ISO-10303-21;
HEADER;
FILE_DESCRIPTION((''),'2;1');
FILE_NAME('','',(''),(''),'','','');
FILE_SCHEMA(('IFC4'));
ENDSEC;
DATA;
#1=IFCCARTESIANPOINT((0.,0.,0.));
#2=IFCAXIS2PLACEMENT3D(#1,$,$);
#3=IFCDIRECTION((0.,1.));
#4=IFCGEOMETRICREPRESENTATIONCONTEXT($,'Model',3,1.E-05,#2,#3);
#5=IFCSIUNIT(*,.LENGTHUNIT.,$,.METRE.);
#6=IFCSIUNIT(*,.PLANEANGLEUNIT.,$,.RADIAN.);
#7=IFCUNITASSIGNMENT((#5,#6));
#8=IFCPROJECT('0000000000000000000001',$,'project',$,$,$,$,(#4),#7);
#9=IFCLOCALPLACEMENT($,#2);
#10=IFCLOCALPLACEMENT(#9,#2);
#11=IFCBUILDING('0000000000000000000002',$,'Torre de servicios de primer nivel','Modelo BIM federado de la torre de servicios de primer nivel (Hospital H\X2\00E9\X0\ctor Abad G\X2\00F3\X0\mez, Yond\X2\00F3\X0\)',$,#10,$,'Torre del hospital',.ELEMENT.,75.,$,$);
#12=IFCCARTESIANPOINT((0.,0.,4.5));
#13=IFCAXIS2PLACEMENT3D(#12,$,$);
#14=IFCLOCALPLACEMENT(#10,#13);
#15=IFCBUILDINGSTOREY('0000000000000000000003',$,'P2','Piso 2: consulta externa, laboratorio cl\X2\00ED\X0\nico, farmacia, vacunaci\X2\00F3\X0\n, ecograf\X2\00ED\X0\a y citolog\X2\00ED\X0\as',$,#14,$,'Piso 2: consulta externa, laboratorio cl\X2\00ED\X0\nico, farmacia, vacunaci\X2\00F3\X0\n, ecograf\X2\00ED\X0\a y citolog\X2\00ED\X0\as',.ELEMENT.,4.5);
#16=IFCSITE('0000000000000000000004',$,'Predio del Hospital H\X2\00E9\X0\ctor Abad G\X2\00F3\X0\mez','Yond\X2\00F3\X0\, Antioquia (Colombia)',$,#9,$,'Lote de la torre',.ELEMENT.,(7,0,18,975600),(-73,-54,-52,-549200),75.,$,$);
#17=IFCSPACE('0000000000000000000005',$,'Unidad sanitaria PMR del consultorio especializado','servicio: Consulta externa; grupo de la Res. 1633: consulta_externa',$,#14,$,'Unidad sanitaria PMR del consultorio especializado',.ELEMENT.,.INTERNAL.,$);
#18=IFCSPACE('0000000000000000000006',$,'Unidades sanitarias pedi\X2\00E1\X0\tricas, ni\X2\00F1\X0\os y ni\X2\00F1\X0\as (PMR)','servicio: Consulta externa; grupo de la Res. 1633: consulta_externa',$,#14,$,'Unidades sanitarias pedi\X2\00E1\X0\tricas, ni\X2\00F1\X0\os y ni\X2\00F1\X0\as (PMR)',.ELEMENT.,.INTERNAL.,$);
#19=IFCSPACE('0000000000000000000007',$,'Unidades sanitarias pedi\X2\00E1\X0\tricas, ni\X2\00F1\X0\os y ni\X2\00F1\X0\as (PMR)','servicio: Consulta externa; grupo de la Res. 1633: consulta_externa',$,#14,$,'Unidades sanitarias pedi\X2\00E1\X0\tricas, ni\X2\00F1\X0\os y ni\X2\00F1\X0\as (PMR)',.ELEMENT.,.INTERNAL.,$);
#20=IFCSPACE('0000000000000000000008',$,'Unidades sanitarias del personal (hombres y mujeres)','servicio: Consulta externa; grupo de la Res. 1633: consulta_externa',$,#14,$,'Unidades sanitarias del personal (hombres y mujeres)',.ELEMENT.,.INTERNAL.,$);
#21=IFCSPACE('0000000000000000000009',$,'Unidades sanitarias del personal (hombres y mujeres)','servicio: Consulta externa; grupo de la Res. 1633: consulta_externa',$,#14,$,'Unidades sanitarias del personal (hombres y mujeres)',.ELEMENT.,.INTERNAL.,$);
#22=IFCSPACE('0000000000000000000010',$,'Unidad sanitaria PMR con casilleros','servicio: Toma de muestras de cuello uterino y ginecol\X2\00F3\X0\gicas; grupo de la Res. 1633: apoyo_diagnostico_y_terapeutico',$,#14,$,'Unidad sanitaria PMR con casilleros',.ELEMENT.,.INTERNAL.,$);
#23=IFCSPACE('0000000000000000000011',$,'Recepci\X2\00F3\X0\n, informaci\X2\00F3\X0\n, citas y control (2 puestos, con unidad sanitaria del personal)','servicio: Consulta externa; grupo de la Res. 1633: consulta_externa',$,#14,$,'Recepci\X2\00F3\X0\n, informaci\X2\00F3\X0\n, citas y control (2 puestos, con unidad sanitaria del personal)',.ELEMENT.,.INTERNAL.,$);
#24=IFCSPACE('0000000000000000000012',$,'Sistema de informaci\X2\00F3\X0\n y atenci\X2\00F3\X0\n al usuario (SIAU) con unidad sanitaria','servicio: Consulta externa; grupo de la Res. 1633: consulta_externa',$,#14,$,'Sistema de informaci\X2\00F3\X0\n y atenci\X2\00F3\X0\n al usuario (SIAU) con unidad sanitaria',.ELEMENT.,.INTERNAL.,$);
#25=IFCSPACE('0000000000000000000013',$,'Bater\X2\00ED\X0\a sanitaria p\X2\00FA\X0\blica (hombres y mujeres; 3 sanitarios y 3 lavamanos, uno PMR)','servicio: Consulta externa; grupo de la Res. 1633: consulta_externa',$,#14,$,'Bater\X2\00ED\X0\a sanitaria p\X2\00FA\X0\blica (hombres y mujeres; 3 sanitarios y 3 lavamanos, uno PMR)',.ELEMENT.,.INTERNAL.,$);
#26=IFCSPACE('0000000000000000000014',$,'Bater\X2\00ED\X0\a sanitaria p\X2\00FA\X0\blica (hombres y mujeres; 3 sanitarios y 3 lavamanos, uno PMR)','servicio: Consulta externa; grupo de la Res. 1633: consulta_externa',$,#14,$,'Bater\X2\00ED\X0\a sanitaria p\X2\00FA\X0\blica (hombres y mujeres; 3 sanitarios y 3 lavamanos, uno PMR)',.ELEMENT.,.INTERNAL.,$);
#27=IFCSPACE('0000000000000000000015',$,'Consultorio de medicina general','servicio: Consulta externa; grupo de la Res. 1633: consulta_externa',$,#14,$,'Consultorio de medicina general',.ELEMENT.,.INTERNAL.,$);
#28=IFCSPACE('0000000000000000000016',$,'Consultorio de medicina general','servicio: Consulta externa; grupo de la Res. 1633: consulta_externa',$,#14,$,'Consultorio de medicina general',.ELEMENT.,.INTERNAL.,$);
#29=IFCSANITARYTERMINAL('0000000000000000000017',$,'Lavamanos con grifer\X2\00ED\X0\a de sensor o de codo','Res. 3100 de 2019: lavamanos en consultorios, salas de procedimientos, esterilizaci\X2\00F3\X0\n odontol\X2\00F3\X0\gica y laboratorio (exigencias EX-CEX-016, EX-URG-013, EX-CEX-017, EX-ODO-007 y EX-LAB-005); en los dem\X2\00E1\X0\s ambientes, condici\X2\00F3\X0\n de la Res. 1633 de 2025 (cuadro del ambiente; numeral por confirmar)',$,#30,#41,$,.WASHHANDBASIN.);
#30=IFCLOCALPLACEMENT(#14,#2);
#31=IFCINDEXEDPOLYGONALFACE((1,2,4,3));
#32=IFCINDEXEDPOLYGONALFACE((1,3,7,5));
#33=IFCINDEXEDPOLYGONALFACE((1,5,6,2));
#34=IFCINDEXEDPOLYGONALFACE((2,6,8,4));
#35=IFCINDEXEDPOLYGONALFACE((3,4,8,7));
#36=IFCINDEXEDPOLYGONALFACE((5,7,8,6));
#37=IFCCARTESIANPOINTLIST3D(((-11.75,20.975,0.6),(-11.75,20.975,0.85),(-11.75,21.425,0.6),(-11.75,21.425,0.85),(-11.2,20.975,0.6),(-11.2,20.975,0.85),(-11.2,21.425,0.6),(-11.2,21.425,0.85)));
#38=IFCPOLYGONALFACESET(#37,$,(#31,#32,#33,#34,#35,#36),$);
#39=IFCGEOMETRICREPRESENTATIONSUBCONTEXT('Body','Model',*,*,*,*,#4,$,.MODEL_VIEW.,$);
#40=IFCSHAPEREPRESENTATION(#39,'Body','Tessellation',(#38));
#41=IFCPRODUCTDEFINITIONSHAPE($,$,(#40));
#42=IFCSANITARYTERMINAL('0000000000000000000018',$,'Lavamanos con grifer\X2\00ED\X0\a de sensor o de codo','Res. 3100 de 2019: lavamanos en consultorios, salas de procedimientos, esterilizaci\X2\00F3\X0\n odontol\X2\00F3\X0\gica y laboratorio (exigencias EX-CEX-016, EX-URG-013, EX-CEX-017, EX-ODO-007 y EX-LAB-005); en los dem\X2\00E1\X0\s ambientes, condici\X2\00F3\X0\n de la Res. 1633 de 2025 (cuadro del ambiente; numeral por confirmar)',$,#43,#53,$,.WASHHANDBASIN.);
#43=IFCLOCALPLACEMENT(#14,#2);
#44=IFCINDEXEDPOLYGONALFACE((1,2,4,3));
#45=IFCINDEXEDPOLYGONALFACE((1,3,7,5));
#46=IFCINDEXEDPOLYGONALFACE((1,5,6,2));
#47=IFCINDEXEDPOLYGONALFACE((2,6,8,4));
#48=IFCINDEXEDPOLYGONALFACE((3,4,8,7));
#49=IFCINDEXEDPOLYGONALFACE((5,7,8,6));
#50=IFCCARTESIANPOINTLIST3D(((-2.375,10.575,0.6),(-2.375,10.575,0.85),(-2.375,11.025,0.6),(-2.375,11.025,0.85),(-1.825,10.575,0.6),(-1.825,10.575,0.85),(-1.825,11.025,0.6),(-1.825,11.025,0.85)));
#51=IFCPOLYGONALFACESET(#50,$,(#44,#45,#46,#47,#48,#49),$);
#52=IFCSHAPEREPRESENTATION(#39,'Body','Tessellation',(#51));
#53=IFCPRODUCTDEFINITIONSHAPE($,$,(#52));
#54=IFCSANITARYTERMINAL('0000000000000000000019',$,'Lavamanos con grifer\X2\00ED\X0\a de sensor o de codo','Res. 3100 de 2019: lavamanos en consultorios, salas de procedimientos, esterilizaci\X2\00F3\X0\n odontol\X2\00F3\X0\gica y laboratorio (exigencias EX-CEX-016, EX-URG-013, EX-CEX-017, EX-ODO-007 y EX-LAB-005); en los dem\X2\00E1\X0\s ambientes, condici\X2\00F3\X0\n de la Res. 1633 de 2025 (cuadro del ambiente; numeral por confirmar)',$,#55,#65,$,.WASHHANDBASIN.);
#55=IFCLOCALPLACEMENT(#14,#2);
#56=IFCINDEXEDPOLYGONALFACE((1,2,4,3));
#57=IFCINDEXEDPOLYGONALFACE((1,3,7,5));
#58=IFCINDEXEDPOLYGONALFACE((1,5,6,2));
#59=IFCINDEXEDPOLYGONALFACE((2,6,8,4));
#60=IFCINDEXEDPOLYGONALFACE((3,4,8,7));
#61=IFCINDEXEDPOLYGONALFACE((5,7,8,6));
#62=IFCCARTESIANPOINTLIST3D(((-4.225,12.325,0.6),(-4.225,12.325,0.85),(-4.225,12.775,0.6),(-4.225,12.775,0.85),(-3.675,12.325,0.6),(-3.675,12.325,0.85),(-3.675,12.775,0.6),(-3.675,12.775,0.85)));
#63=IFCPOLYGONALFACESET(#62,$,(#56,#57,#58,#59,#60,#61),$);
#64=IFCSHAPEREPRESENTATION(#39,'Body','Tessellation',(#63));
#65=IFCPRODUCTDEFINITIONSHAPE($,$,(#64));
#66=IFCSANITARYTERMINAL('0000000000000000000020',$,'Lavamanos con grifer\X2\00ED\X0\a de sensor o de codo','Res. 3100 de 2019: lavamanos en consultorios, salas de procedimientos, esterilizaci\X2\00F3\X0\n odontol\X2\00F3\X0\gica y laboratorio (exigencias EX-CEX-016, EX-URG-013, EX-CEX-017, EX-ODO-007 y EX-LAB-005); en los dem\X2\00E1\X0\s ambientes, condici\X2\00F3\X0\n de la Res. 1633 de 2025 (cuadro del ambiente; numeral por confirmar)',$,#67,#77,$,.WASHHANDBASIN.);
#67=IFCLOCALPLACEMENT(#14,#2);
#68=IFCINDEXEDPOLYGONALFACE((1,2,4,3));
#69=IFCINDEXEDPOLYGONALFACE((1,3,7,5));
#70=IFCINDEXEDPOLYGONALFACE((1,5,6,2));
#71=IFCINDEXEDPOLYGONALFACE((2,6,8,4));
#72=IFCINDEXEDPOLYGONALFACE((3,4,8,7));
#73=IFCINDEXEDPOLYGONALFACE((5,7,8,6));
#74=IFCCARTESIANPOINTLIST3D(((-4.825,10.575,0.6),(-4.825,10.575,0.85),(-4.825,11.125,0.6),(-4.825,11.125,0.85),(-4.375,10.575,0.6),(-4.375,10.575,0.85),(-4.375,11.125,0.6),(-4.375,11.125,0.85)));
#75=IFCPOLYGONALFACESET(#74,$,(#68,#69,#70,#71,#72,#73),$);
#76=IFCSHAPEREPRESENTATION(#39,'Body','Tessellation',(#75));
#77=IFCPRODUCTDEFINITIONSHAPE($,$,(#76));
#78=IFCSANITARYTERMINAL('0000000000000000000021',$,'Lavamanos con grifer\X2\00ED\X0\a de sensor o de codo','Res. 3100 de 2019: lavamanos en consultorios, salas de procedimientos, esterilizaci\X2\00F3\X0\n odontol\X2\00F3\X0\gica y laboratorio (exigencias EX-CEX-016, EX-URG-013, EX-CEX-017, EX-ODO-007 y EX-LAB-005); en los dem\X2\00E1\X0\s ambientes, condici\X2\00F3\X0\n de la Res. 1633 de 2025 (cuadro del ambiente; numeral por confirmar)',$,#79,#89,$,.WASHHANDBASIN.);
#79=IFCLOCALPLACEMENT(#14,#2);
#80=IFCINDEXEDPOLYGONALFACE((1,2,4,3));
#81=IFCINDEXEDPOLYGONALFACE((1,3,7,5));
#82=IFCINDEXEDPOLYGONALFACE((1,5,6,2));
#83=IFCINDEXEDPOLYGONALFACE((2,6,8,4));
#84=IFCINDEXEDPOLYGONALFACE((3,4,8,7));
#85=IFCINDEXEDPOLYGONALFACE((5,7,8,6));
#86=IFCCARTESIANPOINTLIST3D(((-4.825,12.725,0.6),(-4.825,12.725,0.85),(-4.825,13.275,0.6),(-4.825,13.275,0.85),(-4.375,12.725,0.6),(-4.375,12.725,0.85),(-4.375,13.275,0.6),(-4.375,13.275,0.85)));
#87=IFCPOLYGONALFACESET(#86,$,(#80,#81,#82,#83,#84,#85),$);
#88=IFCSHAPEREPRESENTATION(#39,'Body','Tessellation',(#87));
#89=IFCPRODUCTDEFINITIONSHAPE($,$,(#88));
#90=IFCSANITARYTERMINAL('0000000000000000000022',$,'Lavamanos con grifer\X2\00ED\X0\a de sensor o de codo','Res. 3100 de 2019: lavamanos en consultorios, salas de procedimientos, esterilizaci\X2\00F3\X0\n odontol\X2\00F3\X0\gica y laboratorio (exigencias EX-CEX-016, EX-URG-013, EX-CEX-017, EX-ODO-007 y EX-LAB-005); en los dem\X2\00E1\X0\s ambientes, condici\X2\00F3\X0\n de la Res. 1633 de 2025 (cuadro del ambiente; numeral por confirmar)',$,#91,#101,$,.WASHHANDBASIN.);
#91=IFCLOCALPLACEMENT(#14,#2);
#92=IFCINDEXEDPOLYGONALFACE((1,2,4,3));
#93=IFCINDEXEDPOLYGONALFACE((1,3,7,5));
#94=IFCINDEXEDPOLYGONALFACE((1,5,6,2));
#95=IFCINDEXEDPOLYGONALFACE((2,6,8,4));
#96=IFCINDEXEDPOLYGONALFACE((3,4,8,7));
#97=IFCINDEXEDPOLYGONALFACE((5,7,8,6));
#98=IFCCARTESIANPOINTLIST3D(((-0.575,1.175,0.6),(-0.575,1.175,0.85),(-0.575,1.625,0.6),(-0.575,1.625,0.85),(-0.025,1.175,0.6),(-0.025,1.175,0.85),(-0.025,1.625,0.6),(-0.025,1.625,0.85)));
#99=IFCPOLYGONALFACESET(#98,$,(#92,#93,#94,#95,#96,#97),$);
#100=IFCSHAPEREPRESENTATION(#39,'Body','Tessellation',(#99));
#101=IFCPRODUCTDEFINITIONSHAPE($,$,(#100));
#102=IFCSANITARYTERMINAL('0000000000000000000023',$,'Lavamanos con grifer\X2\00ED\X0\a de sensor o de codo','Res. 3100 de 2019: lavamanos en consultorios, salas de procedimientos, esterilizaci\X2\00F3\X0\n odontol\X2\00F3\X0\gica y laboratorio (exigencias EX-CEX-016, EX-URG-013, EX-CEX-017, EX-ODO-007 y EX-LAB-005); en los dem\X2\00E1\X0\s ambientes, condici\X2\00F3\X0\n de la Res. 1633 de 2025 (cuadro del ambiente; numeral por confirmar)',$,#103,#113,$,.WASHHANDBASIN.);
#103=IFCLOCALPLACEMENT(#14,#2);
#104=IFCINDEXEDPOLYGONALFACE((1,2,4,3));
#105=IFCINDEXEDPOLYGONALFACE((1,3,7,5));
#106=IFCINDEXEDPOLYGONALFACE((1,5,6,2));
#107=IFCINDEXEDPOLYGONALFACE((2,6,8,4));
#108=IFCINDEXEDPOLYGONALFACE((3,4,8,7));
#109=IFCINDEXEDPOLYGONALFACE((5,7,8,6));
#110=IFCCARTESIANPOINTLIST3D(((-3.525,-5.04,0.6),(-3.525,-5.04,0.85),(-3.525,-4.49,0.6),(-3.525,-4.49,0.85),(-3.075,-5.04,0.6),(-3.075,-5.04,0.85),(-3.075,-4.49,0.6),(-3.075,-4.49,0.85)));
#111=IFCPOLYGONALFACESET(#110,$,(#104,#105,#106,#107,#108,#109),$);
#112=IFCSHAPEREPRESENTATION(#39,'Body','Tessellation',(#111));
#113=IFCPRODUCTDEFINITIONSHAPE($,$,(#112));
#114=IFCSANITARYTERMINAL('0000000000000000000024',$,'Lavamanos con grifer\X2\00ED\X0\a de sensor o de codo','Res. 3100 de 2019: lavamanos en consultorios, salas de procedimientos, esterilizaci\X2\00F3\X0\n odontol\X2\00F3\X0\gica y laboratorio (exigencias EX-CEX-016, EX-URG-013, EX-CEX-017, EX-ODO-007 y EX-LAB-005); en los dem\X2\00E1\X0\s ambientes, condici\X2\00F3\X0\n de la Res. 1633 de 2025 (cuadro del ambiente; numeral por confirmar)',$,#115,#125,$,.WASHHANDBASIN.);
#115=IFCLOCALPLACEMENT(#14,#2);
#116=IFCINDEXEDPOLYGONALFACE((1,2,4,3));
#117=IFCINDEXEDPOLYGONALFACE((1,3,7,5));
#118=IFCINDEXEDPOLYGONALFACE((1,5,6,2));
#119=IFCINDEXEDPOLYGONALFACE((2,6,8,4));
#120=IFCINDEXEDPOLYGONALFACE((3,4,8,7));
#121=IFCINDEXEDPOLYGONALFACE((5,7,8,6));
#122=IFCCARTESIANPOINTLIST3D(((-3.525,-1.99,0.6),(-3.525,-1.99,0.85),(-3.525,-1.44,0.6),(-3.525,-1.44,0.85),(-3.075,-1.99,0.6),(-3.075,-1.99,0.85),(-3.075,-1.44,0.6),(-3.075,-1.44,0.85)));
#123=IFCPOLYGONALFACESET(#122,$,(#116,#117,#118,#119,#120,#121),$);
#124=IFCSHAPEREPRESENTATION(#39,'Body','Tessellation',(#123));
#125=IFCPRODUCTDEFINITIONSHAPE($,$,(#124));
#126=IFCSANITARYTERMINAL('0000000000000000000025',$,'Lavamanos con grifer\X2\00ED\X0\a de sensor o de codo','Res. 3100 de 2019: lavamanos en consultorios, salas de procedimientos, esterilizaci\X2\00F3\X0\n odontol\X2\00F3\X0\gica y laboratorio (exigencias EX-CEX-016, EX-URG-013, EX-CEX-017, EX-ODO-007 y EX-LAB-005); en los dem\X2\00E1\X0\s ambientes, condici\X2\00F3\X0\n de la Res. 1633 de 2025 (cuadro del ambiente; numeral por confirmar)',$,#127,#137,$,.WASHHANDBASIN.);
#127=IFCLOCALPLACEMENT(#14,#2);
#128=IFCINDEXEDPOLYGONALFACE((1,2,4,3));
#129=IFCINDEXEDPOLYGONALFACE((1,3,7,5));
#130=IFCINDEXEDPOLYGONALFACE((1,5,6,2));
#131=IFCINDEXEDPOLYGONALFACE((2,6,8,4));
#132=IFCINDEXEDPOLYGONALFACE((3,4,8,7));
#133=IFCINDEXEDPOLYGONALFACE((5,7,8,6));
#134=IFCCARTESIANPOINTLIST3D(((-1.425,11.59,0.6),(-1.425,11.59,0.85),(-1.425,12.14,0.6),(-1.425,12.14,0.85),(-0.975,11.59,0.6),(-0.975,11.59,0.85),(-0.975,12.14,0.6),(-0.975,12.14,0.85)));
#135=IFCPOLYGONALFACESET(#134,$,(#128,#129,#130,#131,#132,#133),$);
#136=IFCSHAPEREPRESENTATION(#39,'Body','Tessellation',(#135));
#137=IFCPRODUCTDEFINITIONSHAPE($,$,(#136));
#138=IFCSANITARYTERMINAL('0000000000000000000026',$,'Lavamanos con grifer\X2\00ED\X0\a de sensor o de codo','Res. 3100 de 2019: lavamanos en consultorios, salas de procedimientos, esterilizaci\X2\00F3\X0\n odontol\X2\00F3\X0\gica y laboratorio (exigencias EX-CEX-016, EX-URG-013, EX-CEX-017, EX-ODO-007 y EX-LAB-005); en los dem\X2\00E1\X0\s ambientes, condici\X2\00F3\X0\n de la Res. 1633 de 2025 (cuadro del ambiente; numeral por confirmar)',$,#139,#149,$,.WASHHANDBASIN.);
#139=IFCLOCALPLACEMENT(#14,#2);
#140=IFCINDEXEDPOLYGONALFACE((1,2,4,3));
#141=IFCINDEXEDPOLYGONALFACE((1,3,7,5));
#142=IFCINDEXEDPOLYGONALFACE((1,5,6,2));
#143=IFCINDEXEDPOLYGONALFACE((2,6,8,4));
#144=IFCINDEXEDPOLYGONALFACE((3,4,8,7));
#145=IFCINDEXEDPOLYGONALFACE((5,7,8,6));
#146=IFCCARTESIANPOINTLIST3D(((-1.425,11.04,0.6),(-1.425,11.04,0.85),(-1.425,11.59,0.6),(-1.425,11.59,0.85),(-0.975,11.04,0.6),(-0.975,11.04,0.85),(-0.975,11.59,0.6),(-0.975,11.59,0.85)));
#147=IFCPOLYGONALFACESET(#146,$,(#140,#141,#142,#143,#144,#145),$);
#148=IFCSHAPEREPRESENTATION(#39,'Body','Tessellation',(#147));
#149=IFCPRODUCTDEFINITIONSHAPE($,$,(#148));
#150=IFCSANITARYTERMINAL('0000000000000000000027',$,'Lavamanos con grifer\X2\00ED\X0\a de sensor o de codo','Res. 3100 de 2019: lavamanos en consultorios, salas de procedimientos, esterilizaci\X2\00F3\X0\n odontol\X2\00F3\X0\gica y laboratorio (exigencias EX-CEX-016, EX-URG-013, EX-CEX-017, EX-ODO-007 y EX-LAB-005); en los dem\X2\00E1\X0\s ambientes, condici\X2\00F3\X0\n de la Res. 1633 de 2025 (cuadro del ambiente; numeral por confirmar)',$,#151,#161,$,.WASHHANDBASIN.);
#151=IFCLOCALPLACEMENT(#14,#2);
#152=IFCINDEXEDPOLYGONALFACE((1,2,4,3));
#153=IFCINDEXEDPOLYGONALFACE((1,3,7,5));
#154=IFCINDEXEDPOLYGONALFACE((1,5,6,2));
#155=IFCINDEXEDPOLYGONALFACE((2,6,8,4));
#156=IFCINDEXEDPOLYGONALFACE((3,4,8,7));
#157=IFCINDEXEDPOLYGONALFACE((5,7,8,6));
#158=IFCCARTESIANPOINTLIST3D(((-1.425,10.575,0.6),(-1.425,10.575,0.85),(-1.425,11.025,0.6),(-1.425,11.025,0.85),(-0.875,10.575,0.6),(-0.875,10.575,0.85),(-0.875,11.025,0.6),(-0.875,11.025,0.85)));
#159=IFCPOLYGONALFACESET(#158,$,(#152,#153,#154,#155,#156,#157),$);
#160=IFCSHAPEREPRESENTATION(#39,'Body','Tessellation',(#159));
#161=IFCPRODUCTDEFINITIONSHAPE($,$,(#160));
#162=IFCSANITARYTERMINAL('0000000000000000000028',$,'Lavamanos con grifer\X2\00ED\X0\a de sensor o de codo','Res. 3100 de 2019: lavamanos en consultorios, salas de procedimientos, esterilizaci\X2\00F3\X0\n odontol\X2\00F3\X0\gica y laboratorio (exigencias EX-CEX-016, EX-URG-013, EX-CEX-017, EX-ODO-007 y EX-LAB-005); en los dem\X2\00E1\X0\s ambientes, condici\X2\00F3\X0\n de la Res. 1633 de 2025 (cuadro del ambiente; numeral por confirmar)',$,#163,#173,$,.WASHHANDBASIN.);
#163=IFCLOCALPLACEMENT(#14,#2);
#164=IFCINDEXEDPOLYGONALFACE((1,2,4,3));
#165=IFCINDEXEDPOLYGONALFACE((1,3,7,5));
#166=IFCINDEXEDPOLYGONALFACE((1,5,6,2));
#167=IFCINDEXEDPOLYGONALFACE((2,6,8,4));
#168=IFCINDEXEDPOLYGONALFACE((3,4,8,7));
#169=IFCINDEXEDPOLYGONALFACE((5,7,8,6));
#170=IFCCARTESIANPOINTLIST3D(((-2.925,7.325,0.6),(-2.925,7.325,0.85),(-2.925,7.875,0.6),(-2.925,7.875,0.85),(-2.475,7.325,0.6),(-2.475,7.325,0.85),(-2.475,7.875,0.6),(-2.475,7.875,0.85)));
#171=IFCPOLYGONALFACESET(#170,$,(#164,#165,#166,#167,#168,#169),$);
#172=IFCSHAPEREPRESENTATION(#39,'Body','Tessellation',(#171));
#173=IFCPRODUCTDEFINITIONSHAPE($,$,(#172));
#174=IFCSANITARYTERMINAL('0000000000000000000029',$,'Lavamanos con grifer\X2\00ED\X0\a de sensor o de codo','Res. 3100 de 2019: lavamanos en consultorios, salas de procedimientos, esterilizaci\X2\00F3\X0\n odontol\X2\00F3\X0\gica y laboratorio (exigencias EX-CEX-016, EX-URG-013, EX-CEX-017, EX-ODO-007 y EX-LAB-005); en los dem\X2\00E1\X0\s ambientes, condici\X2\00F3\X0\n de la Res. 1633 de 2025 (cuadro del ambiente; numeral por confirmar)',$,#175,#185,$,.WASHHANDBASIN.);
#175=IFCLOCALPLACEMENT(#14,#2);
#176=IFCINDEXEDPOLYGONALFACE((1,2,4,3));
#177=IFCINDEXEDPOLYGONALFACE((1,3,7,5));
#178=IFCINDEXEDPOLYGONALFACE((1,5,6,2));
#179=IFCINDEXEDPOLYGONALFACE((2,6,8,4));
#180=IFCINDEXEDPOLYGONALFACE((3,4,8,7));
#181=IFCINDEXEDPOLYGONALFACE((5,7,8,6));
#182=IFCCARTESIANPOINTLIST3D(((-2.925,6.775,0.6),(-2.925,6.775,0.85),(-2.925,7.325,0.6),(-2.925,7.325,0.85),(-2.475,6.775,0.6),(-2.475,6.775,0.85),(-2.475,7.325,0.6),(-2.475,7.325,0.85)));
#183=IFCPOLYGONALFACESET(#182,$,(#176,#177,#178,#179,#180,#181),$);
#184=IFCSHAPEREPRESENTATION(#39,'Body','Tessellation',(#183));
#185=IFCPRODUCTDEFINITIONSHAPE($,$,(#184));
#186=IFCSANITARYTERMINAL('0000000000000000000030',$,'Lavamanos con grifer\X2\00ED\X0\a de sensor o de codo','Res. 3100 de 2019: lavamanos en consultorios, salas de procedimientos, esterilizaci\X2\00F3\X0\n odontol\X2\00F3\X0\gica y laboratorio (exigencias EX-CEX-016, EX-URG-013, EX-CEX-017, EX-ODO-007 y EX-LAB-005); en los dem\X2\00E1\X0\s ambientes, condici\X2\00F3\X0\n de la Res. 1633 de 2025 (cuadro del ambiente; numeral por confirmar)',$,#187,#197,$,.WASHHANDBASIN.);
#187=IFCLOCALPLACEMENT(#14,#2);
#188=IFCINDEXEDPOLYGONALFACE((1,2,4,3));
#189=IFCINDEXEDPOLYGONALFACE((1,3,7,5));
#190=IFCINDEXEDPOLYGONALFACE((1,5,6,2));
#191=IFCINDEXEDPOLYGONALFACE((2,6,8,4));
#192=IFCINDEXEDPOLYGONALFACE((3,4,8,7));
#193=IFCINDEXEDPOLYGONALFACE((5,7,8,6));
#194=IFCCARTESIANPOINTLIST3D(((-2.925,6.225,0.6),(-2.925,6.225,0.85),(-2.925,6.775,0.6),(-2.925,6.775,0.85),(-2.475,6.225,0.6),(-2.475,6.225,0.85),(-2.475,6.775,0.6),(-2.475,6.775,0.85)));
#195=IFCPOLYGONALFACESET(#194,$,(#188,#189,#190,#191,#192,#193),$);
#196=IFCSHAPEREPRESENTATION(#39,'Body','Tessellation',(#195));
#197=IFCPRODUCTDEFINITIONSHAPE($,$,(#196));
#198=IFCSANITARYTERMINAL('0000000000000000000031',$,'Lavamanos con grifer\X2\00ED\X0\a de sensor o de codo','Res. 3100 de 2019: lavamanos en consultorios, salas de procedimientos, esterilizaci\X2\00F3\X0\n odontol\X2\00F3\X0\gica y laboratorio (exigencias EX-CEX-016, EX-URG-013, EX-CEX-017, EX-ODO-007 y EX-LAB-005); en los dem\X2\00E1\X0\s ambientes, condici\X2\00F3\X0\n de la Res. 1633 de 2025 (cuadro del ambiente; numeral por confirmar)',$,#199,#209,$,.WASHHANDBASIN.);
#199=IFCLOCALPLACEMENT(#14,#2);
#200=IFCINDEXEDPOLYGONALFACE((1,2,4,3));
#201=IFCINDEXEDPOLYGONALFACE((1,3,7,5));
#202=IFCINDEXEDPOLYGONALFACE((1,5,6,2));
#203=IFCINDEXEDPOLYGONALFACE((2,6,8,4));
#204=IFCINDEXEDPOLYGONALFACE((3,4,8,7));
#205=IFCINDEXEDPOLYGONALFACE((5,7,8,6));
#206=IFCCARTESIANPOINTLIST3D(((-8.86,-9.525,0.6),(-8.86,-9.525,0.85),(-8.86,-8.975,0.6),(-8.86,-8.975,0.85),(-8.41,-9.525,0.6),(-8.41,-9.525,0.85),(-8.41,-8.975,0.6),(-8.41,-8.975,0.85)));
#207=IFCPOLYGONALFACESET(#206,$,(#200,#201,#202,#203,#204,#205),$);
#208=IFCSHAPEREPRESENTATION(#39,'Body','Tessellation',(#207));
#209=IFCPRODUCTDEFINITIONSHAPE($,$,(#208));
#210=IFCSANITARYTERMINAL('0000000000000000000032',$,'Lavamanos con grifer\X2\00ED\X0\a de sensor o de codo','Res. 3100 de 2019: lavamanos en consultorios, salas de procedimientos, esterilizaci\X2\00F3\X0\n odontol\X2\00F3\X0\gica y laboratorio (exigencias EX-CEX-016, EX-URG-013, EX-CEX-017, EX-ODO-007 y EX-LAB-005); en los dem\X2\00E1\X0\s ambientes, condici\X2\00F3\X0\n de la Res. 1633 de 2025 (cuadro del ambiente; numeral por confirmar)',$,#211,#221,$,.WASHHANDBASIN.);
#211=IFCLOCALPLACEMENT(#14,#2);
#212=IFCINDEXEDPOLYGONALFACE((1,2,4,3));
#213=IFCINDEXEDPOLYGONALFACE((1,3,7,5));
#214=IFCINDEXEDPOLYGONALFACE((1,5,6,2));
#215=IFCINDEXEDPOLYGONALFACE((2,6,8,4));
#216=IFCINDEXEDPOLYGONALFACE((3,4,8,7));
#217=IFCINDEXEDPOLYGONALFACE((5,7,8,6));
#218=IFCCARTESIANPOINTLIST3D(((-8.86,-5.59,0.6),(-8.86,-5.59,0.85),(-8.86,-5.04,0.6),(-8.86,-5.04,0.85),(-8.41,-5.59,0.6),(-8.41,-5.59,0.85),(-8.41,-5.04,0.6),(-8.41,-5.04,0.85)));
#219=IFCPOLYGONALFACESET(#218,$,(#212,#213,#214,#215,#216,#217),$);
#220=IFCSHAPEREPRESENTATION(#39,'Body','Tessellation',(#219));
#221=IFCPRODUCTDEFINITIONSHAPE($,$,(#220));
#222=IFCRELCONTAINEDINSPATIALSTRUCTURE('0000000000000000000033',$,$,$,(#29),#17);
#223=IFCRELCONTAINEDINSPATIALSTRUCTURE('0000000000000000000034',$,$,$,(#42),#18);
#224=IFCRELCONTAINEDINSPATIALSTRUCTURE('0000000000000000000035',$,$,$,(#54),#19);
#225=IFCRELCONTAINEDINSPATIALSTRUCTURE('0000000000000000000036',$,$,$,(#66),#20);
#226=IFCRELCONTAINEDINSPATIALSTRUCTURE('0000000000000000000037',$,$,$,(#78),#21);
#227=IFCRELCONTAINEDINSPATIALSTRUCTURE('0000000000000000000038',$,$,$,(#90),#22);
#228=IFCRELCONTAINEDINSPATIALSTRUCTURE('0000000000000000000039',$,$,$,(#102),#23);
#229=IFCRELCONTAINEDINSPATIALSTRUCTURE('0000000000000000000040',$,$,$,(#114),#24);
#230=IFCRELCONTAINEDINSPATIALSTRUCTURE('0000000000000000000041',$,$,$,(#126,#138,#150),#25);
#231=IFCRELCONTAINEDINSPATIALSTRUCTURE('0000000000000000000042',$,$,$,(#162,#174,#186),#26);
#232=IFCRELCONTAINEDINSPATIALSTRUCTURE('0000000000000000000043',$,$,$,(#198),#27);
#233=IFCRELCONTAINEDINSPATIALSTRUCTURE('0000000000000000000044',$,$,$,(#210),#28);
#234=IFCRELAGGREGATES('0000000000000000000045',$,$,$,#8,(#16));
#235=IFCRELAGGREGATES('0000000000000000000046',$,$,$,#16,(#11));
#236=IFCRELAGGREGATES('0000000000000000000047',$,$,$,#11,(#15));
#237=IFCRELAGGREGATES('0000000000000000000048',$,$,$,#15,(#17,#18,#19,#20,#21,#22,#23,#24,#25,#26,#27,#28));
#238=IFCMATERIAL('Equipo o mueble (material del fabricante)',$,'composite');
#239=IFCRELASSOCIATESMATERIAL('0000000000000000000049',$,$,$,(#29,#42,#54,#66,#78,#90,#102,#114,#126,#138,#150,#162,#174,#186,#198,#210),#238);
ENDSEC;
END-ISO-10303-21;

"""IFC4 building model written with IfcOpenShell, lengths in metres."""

from ifc_helpers import new_model, si_unit, direction, frame, origin, place, context, subcontext, project, spatial, rectangle, extrude, material, element, save


model = new_model("IFC4")

# Units and contexts
model_context = context("Model", 3, precision=1e-05, world=origin(), true_north=direction((0.0, 1.0)))
body_context = subcontext(model_context, "Body", "Model", "MODEL_VIEW")
ifc_project = project(units=[si_unit("LENGTHUNIT", "METRE"), si_unit("PLANEANGLEUNIT", "RADIAN")], contexts=[model_context])

# Site, building, storey, space
site_placement = place(None, origin())
site = spatial("IfcSite", under=ifc_project, at=site_placement, Name="Predio del Hospital Héctor Abad Gómez", Description="Yondó, Antioquia (Colombia)", LongName="Lote de la torre", CompositionType="ELEMENT", RefLatitude=(7, 0, 18, 975600), RefLongitude=(-73, -54, -52, -549200), RefElevation=75.0)
building_placement = place(site_placement, origin())
building = spatial("IfcBuilding", under=site, at=building_placement, Name="Torre de servicios de primer nivel", Description="Modelo BIM federado de la torre de servicios de primer nivel (Hospital Héctor Abad Gómez, Yondó)", LongName="Torre del hospital", CompositionType="ELEMENT", ElevationOfRefHeight=75.0)
placement = place(building_placement, frame((0.0, 0.0, 4.5)))
storey = spatial("IfcBuildingStorey", under=building, at=placement, Name="P2", Description="Piso 2: consulta externa, laboratorio clínico, farmacia, vacunación, ecografía y citologías", LongName="Piso 2: consulta externa, laboratorio clínico, farmacia, vacunación, ecografía y citologías", CompositionType="ELEMENT", Elevation=4.5)
space_1 = spatial("IfcSpace", under=storey, at=placement, Name="Unidad sanitaria PMR del consultorio especializado", Description="servicio: Consulta externa; grupo de la Res. 1633: consulta_externa", LongName="Unidad sanitaria PMR del consultorio especializado", CompositionType="ELEMENT", PredefinedType="INTERNAL")

# Sanitary terminal
ifc_material = material(Name="Equipo o mueble (material del fabricante)", Category="composite")
element("IfcSanitaryTerminal", 1, at=placement, inside=space_1, material=ifc_material, Name="Lavamanos con grifería de sensor o de codo", Description="Res. 3100 de 2019: lavamanos en consultorios, salas de procedimientos, esterilización odontológica y laboratorio (exigencias EX-CEX-016, EX-URG-013, EX-CEX-017, EX-ODO-007 y EX-LAB-005); en los demás ambientes, condición de la Res. 1633 de 2025 (cuadro del ambiente; numeral por confirmar)", PredefinedType="WASHHANDBASIN", context=body_context, shape_type="SweptSolid", body=[
    extrude(rectangle(XDim=0.55, YDim=0.45), frame((-11.475, 21.2, 0.6)), (0.0, 0.0, 1.0), 0.25),
])

# Shared definitions
space_2 = spatial("IfcSpace", under=storey, at=placement, Name="Unidades sanitarias pediátricas, niños y niñas (PMR)", Description="servicio: Consulta externa; grupo de la Res. 1633: consulta_externa", LongName="Unidades sanitarias pediátricas, niños y niñas (PMR)", CompositionType="ELEMENT", PredefinedType="INTERNAL")

# Sanitary terminal
element("IfcSanitaryTerminal", 2, at=placement, inside=space_2, material=ifc_material, Name="Lavamanos con grifería de sensor o de codo", Description="Res. 3100 de 2019: lavamanos en consultorios, salas de procedimientos, esterilización odontológica y laboratorio (exigencias EX-CEX-016, EX-URG-013, EX-CEX-017, EX-ODO-007 y EX-LAB-005); en los demás ambientes, condición de la Res. 1633 de 2025 (cuadro del ambiente; numeral por confirmar)", PredefinedType="WASHHANDBASIN", context=body_context, shape_type="SweptSolid", body=[
    extrude(rectangle(XDim=0.55, YDim=0.45), frame((-2.1, 10.8, 0.6)), (0.0, 0.0, 1.0), 0.25),
])

# Shared definitions
space_3 = spatial("IfcSpace", under=storey, at=placement, Name="Unidades sanitarias pediátricas, niños y niñas (PMR)", Description="servicio: Consulta externa; grupo de la Res. 1633: consulta_externa", LongName="Unidades sanitarias pediátricas, niños y niñas (PMR)", CompositionType="ELEMENT", PredefinedType="INTERNAL")

# Sanitary terminal
element("IfcSanitaryTerminal", 3, at=placement, inside=space_3, material=ifc_material, Name="Lavamanos con grifería de sensor o de codo", Description="Res. 3100 de 2019: lavamanos en consultorios, salas de procedimientos, esterilización odontológica y laboratorio (exigencias EX-CEX-016, EX-URG-013, EX-CEX-017, EX-ODO-007 y EX-LAB-005); en los demás ambientes, condición de la Res. 1633 de 2025 (cuadro del ambiente; numeral por confirmar)", PredefinedType="WASHHANDBASIN", context=body_context, shape_type="SweptSolid", body=[
    extrude(rectangle(XDim=0.55, YDim=0.45), frame((-3.95, 12.55, 0.6)), (0.0, 0.0, 1.0), 0.25),
])

# Shared definitions
space_4 = spatial("IfcSpace", under=storey, at=placement, Name="Unidades sanitarias del personal (hombres y mujeres)", Description="servicio: Consulta externa; grupo de la Res. 1633: consulta_externa", LongName="Unidades sanitarias del personal (hombres y mujeres)", CompositionType="ELEMENT", PredefinedType="INTERNAL")

# Sanitary terminal
element("IfcSanitaryTerminal", 4, at=placement, inside=space_4, material=ifc_material, Name="Lavamanos con grifería de sensor o de codo", Description="Res. 3100 de 2019: lavamanos en consultorios, salas de procedimientos, esterilización odontológica y laboratorio (exigencias EX-CEX-016, EX-URG-013, EX-CEX-017, EX-ODO-007 y EX-LAB-005); en los demás ambientes, condición de la Res. 1633 de 2025 (cuadro del ambiente; numeral por confirmar)", PredefinedType="WASHHANDBASIN", context=body_context, shape_type="SweptSolid", body=[
    extrude(rectangle(XDim=0.55, YDim=0.45), frame((-4.6, 10.85, 0.6), z_axis=(0.0, 0.0, 1.0), x_axis=(0.0, 1.0, 0.0)), (0.0, 0.0, 1.0), 0.25),
])

# Shared definitions
space_5 = spatial("IfcSpace", under=storey, at=placement, Name="Unidades sanitarias del personal (hombres y mujeres)", Description="servicio: Consulta externa; grupo de la Res. 1633: consulta_externa", LongName="Unidades sanitarias del personal (hombres y mujeres)", CompositionType="ELEMENT", PredefinedType="INTERNAL")

# Sanitary terminal
element("IfcSanitaryTerminal", 5, at=placement, inside=space_5, material=ifc_material, Name="Lavamanos con grifería de sensor o de codo", Description="Res. 3100 de 2019: lavamanos en consultorios, salas de procedimientos, esterilización odontológica y laboratorio (exigencias EX-CEX-016, EX-URG-013, EX-CEX-017, EX-ODO-007 y EX-LAB-005); en los demás ambientes, condición de la Res. 1633 de 2025 (cuadro del ambiente; numeral por confirmar)", PredefinedType="WASHHANDBASIN", context=body_context, shape_type="SweptSolid", body=[
    extrude(rectangle(XDim=0.55, YDim=0.45), frame((-4.6, 13.0, 0.6), z_axis=(0.0, 0.0, 1.0), x_axis=(0.0, 1.0, 0.0)), (0.0, 0.0, 1.0), 0.25),
])

# Shared definitions
space_6 = spatial("IfcSpace", under=storey, at=placement, Name="Unidad sanitaria PMR con casilleros", Description="servicio: Toma de muestras de cuello uterino y ginecológicas; grupo de la Res. 1633: apoyo_diagnostico_y_terapeutico", LongName="Unidad sanitaria PMR con casilleros", CompositionType="ELEMENT", PredefinedType="INTERNAL")

# Sanitary terminal
element("IfcSanitaryTerminal", 6, at=placement, inside=space_6, material=ifc_material, Name="Lavamanos con grifería de sensor o de codo", Description="Res. 3100 de 2019: lavamanos en consultorios, salas de procedimientos, esterilización odontológica y laboratorio (exigencias EX-CEX-016, EX-URG-013, EX-CEX-017, EX-ODO-007 y EX-LAB-005); en los demás ambientes, condición de la Res. 1633 de 2025 (cuadro del ambiente; numeral por confirmar)", PredefinedType="WASHHANDBASIN", context=body_context, shape_type="SweptSolid", body=[
    extrude(rectangle(XDim=0.55, YDim=0.45), frame((-0.3, 1.4, 0.6)), (0.0, 0.0, 1.0), 0.25),
])

# Shared definitions
space_7 = spatial("IfcSpace", under=storey, at=placement, Name="Recepción, información, citas y control (2 puestos, con unidad sanitaria del personal)", Description="servicio: Consulta externa; grupo de la Res. 1633: consulta_externa", LongName="Recepción, información, citas y control (2 puestos, con unidad sanitaria del personal)", CompositionType="ELEMENT", PredefinedType="INTERNAL")

# Sanitary terminal
element("IfcSanitaryTerminal", 7, at=placement, inside=space_7, material=ifc_material, Name="Lavamanos con grifería de sensor o de codo", Description="Res. 3100 de 2019: lavamanos en consultorios, salas de procedimientos, esterilización odontológica y laboratorio (exigencias EX-CEX-016, EX-URG-013, EX-CEX-017, EX-ODO-007 y EX-LAB-005); en los demás ambientes, condición de la Res. 1633 de 2025 (cuadro del ambiente; numeral por confirmar)", PredefinedType="WASHHANDBASIN", context=body_context, shape_type="SweptSolid", body=[
    extrude(rectangle(XDim=0.55, YDim=0.45), frame((-3.3, -4.765, 0.6), z_axis=(0.0, 0.0, 1.0), x_axis=(0.0, 1.0, 0.0)), (0.0, 0.0, 1.0), 0.25),
])

# Shared definitions
space_8 = spatial("IfcSpace", under=storey, at=placement, Name="Sistema de información y atención al usuario (SIAU) con unidad sanitaria", Description="servicio: Consulta externa; grupo de la Res. 1633: consulta_externa", LongName="Sistema de información y atención al usuario (SIAU) con unidad sanitaria", CompositionType="ELEMENT", PredefinedType="INTERNAL")

# Sanitary terminal
element("IfcSanitaryTerminal", 8, at=placement, inside=space_8, material=ifc_material, Name="Lavamanos con grifería de sensor o de codo", Description="Res. 3100 de 2019: lavamanos en consultorios, salas de procedimientos, esterilización odontológica y laboratorio (exigencias EX-CEX-016, EX-URG-013, EX-CEX-017, EX-ODO-007 y EX-LAB-005); en los demás ambientes, condición de la Res. 1633 de 2025 (cuadro del ambiente; numeral por confirmar)", PredefinedType="WASHHANDBASIN", context=body_context, shape_type="SweptSolid", body=[
    extrude(rectangle(XDim=0.55, YDim=0.45), frame((-3.3, -1.715, 0.6), z_axis=(0.0, 0.0, 1.0), x_axis=(0.0, 1.0, 0.0)), (0.0, 0.0, 1.0), 0.25),
])

# Shared definitions
space_9 = spatial("IfcSpace", under=storey, at=placement, Name="Batería sanitaria pública (hombres y mujeres; 3 sanitarios y 3 lavamanos, uno PMR)", Description="servicio: Consulta externa; grupo de la Res. 1633: consulta_externa", LongName="Batería sanitaria pública (hombres y mujeres; 3 sanitarios y 3 lavamanos, uno PMR)", CompositionType="ELEMENT", PredefinedType="INTERNAL")

# Sanitary terminals
element("IfcSanitaryTerminal", 9, at=placement, inside=space_9, material=ifc_material, Name="Lavamanos con grifería de sensor o de codo", Description="Res. 3100 de 2019: lavamanos en consultorios, salas de procedimientos, esterilización odontológica y laboratorio (exigencias EX-CEX-016, EX-URG-013, EX-CEX-017, EX-ODO-007 y EX-LAB-005); en los demás ambientes, condición de la Res. 1633 de 2025 (cuadro del ambiente; numeral por confirmar)", PredefinedType="WASHHANDBASIN", context=body_context, shape_type="SweptSolid", body=[
    extrude(rectangle(XDim=0.55, YDim=0.45), frame((-1.2, 11.865, 0.6), z_axis=(0.0, 0.0, 1.0), x_axis=(0.0, -1.0, 0.0)), (0.0, 0.0, 1.0), 0.25),
])
element("IfcSanitaryTerminal", 10, at=placement, inside=space_9, material=ifc_material, Name="Lavamanos con grifería de sensor o de codo", Description="Res. 3100 de 2019: lavamanos en consultorios, salas de procedimientos, esterilización odontológica y laboratorio (exigencias EX-CEX-016, EX-URG-013, EX-CEX-017, EX-ODO-007 y EX-LAB-005); en los demás ambientes, condición de la Res. 1633 de 2025 (cuadro del ambiente; numeral por confirmar)", PredefinedType="WASHHANDBASIN", context=body_context, shape_type="SweptSolid", body=[
    extrude(rectangle(XDim=0.55, YDim=0.45), frame((-1.2, 11.315, 0.6), z_axis=(0.0, 0.0, 1.0), x_axis=(0.0, -1.0, 0.0)), (0.0, 0.0, 1.0), 0.25),
])
element("IfcSanitaryTerminal", 11, at=placement, inside=space_9, material=ifc_material, Name="Lavamanos con grifería de sensor o de codo", Description="Res. 3100 de 2019: lavamanos en consultorios, salas de procedimientos, esterilización odontológica y laboratorio (exigencias EX-CEX-016, EX-URG-013, EX-CEX-017, EX-ODO-007 y EX-LAB-005); en los demás ambientes, condición de la Res. 1633 de 2025 (cuadro del ambiente; numeral por confirmar)", PredefinedType="WASHHANDBASIN", context=body_context, shape_type="SweptSolid", body=[
    extrude(rectangle(XDim=0.55, YDim=0.45), frame((-1.15, 10.8, 0.6)), (0.0, 0.0, 1.0), 0.25),
])

# Shared definitions
space_10 = spatial("IfcSpace", under=storey, at=placement, Name="Batería sanitaria pública (hombres y mujeres; 3 sanitarios y 3 lavamanos, uno PMR)", Description="servicio: Consulta externa; grupo de la Res. 1633: consulta_externa", LongName="Batería sanitaria pública (hombres y mujeres; 3 sanitarios y 3 lavamanos, uno PMR)", CompositionType="ELEMENT", PredefinedType="INTERNAL")

# Sanitary terminals
element("IfcSanitaryTerminal", 12, at=placement, inside=space_10, material=ifc_material, Name="Lavamanos con grifería de sensor o de codo", Description="Res. 3100 de 2019: lavamanos en consultorios, salas de procedimientos, esterilización odontológica y laboratorio (exigencias EX-CEX-016, EX-URG-013, EX-CEX-017, EX-ODO-007 y EX-LAB-005); en los demás ambientes, condición de la Res. 1633 de 2025 (cuadro del ambiente; numeral por confirmar)", PredefinedType="WASHHANDBASIN", context=body_context, shape_type="SweptSolid", body=[
    extrude(rectangle(XDim=0.55, YDim=0.45), frame((-2.7, 7.6, 0.6), z_axis=(0.0, 0.0, 1.0), x_axis=(0.0, -1.0, 0.0)), (0.0, 0.0, 1.0), 0.25),
])
element("IfcSanitaryTerminal", 13, at=placement, inside=space_10, material=ifc_material, Name="Lavamanos con grifería de sensor o de codo", Description="Res. 3100 de 2019: lavamanos en consultorios, salas de procedimientos, esterilización odontológica y laboratorio (exigencias EX-CEX-016, EX-URG-013, EX-CEX-017, EX-ODO-007 y EX-LAB-005); en los demás ambientes, condición de la Res. 1633 de 2025 (cuadro del ambiente; numeral por confirmar)", PredefinedType="WASHHANDBASIN", context=body_context, shape_type="SweptSolid", body=[
    extrude(rectangle(XDim=0.55, YDim=0.45), frame((-2.7, 7.05, 0.6), z_axis=(0.0, 0.0, 1.0), x_axis=(0.0, -1.0, 0.0)), (0.0, 0.0, 1.0), 0.25),
])
element("IfcSanitaryTerminal", 14, at=placement, inside=space_10, material=ifc_material, Name="Lavamanos con grifería de sensor o de codo", Description="Res. 3100 de 2019: lavamanos en consultorios, salas de procedimientos, esterilización odontológica y laboratorio (exigencias EX-CEX-016, EX-URG-013, EX-CEX-017, EX-ODO-007 y EX-LAB-005); en los demás ambientes, condición de la Res. 1633 de 2025 (cuadro del ambiente; numeral por confirmar)", PredefinedType="WASHHANDBASIN", context=body_context, shape_type="SweptSolid", body=[
    extrude(rectangle(XDim=0.55, YDim=0.45), frame((-2.7, 6.5, 0.6), z_axis=(0.0, 0.0, 1.0), x_axis=(0.0, -1.0, 0.0)), (0.0, 0.0, 1.0), 0.25),
])

# Shared definitions
space_11 = spatial("IfcSpace", under=storey, at=placement, Name="Consultorio de medicina general", Description="servicio: Consulta externa; grupo de la Res. 1633: consulta_externa", LongName="Consultorio de medicina general", CompositionType="ELEMENT", PredefinedType="INTERNAL")

# Sanitary terminal
element("IfcSanitaryTerminal", 15, at=placement, inside=space_11, material=ifc_material, Name="Lavamanos con grifería de sensor o de codo", Description="Res. 3100 de 2019: lavamanos en consultorios, salas de procedimientos, esterilización odontológica y laboratorio (exigencias EX-CEX-016, EX-URG-013, EX-CEX-017, EX-ODO-007 y EX-LAB-005); en los demás ambientes, condición de la Res. 1633 de 2025 (cuadro del ambiente; numeral por confirmar)", PredefinedType="WASHHANDBASIN", context=body_context, shape_type="SweptSolid", body=[
    extrude(rectangle(XDim=0.55, YDim=0.45), frame((-8.635, -9.25, 0.6), z_axis=(0.0, 0.0, 1.0), x_axis=(0.0, 1.0, 0.0)), (0.0, 0.0, 1.0), 0.25),
])

# Shared definitions
space_12 = spatial("IfcSpace", under=storey, at=placement, Name="Consultorio de medicina general", Description="servicio: Consulta externa; grupo de la Res. 1633: consulta_externa", LongName="Consultorio de medicina general", CompositionType="ELEMENT", PredefinedType="INTERNAL")

# Sanitary terminal
element("IfcSanitaryTerminal", 16, at=placement, inside=space_12, material=ifc_material, Name="Lavamanos con grifería de sensor o de codo", Description="Res. 3100 de 2019: lavamanos en consultorios, salas de procedimientos, esterilización odontológica y laboratorio (exigencias EX-CEX-016, EX-URG-013, EX-CEX-017, EX-ODO-007 y EX-LAB-005); en los demás ambientes, condición de la Res. 1633 de 2025 (cuadro del ambiente; numeral por confirmar)", PredefinedType="WASHHANDBASIN", context=body_context, shape_type="SweptSolid", body=[
    extrude(rectangle(XDim=0.55, YDim=0.45), frame((-8.635, -5.315, 0.6), z_axis=(0.0, 0.0, 1.0), x_axis=(0.0, 1.0, 0.0)), (0.0, 0.0, 1.0), 0.25),
])

save(model, "model.ifc")
